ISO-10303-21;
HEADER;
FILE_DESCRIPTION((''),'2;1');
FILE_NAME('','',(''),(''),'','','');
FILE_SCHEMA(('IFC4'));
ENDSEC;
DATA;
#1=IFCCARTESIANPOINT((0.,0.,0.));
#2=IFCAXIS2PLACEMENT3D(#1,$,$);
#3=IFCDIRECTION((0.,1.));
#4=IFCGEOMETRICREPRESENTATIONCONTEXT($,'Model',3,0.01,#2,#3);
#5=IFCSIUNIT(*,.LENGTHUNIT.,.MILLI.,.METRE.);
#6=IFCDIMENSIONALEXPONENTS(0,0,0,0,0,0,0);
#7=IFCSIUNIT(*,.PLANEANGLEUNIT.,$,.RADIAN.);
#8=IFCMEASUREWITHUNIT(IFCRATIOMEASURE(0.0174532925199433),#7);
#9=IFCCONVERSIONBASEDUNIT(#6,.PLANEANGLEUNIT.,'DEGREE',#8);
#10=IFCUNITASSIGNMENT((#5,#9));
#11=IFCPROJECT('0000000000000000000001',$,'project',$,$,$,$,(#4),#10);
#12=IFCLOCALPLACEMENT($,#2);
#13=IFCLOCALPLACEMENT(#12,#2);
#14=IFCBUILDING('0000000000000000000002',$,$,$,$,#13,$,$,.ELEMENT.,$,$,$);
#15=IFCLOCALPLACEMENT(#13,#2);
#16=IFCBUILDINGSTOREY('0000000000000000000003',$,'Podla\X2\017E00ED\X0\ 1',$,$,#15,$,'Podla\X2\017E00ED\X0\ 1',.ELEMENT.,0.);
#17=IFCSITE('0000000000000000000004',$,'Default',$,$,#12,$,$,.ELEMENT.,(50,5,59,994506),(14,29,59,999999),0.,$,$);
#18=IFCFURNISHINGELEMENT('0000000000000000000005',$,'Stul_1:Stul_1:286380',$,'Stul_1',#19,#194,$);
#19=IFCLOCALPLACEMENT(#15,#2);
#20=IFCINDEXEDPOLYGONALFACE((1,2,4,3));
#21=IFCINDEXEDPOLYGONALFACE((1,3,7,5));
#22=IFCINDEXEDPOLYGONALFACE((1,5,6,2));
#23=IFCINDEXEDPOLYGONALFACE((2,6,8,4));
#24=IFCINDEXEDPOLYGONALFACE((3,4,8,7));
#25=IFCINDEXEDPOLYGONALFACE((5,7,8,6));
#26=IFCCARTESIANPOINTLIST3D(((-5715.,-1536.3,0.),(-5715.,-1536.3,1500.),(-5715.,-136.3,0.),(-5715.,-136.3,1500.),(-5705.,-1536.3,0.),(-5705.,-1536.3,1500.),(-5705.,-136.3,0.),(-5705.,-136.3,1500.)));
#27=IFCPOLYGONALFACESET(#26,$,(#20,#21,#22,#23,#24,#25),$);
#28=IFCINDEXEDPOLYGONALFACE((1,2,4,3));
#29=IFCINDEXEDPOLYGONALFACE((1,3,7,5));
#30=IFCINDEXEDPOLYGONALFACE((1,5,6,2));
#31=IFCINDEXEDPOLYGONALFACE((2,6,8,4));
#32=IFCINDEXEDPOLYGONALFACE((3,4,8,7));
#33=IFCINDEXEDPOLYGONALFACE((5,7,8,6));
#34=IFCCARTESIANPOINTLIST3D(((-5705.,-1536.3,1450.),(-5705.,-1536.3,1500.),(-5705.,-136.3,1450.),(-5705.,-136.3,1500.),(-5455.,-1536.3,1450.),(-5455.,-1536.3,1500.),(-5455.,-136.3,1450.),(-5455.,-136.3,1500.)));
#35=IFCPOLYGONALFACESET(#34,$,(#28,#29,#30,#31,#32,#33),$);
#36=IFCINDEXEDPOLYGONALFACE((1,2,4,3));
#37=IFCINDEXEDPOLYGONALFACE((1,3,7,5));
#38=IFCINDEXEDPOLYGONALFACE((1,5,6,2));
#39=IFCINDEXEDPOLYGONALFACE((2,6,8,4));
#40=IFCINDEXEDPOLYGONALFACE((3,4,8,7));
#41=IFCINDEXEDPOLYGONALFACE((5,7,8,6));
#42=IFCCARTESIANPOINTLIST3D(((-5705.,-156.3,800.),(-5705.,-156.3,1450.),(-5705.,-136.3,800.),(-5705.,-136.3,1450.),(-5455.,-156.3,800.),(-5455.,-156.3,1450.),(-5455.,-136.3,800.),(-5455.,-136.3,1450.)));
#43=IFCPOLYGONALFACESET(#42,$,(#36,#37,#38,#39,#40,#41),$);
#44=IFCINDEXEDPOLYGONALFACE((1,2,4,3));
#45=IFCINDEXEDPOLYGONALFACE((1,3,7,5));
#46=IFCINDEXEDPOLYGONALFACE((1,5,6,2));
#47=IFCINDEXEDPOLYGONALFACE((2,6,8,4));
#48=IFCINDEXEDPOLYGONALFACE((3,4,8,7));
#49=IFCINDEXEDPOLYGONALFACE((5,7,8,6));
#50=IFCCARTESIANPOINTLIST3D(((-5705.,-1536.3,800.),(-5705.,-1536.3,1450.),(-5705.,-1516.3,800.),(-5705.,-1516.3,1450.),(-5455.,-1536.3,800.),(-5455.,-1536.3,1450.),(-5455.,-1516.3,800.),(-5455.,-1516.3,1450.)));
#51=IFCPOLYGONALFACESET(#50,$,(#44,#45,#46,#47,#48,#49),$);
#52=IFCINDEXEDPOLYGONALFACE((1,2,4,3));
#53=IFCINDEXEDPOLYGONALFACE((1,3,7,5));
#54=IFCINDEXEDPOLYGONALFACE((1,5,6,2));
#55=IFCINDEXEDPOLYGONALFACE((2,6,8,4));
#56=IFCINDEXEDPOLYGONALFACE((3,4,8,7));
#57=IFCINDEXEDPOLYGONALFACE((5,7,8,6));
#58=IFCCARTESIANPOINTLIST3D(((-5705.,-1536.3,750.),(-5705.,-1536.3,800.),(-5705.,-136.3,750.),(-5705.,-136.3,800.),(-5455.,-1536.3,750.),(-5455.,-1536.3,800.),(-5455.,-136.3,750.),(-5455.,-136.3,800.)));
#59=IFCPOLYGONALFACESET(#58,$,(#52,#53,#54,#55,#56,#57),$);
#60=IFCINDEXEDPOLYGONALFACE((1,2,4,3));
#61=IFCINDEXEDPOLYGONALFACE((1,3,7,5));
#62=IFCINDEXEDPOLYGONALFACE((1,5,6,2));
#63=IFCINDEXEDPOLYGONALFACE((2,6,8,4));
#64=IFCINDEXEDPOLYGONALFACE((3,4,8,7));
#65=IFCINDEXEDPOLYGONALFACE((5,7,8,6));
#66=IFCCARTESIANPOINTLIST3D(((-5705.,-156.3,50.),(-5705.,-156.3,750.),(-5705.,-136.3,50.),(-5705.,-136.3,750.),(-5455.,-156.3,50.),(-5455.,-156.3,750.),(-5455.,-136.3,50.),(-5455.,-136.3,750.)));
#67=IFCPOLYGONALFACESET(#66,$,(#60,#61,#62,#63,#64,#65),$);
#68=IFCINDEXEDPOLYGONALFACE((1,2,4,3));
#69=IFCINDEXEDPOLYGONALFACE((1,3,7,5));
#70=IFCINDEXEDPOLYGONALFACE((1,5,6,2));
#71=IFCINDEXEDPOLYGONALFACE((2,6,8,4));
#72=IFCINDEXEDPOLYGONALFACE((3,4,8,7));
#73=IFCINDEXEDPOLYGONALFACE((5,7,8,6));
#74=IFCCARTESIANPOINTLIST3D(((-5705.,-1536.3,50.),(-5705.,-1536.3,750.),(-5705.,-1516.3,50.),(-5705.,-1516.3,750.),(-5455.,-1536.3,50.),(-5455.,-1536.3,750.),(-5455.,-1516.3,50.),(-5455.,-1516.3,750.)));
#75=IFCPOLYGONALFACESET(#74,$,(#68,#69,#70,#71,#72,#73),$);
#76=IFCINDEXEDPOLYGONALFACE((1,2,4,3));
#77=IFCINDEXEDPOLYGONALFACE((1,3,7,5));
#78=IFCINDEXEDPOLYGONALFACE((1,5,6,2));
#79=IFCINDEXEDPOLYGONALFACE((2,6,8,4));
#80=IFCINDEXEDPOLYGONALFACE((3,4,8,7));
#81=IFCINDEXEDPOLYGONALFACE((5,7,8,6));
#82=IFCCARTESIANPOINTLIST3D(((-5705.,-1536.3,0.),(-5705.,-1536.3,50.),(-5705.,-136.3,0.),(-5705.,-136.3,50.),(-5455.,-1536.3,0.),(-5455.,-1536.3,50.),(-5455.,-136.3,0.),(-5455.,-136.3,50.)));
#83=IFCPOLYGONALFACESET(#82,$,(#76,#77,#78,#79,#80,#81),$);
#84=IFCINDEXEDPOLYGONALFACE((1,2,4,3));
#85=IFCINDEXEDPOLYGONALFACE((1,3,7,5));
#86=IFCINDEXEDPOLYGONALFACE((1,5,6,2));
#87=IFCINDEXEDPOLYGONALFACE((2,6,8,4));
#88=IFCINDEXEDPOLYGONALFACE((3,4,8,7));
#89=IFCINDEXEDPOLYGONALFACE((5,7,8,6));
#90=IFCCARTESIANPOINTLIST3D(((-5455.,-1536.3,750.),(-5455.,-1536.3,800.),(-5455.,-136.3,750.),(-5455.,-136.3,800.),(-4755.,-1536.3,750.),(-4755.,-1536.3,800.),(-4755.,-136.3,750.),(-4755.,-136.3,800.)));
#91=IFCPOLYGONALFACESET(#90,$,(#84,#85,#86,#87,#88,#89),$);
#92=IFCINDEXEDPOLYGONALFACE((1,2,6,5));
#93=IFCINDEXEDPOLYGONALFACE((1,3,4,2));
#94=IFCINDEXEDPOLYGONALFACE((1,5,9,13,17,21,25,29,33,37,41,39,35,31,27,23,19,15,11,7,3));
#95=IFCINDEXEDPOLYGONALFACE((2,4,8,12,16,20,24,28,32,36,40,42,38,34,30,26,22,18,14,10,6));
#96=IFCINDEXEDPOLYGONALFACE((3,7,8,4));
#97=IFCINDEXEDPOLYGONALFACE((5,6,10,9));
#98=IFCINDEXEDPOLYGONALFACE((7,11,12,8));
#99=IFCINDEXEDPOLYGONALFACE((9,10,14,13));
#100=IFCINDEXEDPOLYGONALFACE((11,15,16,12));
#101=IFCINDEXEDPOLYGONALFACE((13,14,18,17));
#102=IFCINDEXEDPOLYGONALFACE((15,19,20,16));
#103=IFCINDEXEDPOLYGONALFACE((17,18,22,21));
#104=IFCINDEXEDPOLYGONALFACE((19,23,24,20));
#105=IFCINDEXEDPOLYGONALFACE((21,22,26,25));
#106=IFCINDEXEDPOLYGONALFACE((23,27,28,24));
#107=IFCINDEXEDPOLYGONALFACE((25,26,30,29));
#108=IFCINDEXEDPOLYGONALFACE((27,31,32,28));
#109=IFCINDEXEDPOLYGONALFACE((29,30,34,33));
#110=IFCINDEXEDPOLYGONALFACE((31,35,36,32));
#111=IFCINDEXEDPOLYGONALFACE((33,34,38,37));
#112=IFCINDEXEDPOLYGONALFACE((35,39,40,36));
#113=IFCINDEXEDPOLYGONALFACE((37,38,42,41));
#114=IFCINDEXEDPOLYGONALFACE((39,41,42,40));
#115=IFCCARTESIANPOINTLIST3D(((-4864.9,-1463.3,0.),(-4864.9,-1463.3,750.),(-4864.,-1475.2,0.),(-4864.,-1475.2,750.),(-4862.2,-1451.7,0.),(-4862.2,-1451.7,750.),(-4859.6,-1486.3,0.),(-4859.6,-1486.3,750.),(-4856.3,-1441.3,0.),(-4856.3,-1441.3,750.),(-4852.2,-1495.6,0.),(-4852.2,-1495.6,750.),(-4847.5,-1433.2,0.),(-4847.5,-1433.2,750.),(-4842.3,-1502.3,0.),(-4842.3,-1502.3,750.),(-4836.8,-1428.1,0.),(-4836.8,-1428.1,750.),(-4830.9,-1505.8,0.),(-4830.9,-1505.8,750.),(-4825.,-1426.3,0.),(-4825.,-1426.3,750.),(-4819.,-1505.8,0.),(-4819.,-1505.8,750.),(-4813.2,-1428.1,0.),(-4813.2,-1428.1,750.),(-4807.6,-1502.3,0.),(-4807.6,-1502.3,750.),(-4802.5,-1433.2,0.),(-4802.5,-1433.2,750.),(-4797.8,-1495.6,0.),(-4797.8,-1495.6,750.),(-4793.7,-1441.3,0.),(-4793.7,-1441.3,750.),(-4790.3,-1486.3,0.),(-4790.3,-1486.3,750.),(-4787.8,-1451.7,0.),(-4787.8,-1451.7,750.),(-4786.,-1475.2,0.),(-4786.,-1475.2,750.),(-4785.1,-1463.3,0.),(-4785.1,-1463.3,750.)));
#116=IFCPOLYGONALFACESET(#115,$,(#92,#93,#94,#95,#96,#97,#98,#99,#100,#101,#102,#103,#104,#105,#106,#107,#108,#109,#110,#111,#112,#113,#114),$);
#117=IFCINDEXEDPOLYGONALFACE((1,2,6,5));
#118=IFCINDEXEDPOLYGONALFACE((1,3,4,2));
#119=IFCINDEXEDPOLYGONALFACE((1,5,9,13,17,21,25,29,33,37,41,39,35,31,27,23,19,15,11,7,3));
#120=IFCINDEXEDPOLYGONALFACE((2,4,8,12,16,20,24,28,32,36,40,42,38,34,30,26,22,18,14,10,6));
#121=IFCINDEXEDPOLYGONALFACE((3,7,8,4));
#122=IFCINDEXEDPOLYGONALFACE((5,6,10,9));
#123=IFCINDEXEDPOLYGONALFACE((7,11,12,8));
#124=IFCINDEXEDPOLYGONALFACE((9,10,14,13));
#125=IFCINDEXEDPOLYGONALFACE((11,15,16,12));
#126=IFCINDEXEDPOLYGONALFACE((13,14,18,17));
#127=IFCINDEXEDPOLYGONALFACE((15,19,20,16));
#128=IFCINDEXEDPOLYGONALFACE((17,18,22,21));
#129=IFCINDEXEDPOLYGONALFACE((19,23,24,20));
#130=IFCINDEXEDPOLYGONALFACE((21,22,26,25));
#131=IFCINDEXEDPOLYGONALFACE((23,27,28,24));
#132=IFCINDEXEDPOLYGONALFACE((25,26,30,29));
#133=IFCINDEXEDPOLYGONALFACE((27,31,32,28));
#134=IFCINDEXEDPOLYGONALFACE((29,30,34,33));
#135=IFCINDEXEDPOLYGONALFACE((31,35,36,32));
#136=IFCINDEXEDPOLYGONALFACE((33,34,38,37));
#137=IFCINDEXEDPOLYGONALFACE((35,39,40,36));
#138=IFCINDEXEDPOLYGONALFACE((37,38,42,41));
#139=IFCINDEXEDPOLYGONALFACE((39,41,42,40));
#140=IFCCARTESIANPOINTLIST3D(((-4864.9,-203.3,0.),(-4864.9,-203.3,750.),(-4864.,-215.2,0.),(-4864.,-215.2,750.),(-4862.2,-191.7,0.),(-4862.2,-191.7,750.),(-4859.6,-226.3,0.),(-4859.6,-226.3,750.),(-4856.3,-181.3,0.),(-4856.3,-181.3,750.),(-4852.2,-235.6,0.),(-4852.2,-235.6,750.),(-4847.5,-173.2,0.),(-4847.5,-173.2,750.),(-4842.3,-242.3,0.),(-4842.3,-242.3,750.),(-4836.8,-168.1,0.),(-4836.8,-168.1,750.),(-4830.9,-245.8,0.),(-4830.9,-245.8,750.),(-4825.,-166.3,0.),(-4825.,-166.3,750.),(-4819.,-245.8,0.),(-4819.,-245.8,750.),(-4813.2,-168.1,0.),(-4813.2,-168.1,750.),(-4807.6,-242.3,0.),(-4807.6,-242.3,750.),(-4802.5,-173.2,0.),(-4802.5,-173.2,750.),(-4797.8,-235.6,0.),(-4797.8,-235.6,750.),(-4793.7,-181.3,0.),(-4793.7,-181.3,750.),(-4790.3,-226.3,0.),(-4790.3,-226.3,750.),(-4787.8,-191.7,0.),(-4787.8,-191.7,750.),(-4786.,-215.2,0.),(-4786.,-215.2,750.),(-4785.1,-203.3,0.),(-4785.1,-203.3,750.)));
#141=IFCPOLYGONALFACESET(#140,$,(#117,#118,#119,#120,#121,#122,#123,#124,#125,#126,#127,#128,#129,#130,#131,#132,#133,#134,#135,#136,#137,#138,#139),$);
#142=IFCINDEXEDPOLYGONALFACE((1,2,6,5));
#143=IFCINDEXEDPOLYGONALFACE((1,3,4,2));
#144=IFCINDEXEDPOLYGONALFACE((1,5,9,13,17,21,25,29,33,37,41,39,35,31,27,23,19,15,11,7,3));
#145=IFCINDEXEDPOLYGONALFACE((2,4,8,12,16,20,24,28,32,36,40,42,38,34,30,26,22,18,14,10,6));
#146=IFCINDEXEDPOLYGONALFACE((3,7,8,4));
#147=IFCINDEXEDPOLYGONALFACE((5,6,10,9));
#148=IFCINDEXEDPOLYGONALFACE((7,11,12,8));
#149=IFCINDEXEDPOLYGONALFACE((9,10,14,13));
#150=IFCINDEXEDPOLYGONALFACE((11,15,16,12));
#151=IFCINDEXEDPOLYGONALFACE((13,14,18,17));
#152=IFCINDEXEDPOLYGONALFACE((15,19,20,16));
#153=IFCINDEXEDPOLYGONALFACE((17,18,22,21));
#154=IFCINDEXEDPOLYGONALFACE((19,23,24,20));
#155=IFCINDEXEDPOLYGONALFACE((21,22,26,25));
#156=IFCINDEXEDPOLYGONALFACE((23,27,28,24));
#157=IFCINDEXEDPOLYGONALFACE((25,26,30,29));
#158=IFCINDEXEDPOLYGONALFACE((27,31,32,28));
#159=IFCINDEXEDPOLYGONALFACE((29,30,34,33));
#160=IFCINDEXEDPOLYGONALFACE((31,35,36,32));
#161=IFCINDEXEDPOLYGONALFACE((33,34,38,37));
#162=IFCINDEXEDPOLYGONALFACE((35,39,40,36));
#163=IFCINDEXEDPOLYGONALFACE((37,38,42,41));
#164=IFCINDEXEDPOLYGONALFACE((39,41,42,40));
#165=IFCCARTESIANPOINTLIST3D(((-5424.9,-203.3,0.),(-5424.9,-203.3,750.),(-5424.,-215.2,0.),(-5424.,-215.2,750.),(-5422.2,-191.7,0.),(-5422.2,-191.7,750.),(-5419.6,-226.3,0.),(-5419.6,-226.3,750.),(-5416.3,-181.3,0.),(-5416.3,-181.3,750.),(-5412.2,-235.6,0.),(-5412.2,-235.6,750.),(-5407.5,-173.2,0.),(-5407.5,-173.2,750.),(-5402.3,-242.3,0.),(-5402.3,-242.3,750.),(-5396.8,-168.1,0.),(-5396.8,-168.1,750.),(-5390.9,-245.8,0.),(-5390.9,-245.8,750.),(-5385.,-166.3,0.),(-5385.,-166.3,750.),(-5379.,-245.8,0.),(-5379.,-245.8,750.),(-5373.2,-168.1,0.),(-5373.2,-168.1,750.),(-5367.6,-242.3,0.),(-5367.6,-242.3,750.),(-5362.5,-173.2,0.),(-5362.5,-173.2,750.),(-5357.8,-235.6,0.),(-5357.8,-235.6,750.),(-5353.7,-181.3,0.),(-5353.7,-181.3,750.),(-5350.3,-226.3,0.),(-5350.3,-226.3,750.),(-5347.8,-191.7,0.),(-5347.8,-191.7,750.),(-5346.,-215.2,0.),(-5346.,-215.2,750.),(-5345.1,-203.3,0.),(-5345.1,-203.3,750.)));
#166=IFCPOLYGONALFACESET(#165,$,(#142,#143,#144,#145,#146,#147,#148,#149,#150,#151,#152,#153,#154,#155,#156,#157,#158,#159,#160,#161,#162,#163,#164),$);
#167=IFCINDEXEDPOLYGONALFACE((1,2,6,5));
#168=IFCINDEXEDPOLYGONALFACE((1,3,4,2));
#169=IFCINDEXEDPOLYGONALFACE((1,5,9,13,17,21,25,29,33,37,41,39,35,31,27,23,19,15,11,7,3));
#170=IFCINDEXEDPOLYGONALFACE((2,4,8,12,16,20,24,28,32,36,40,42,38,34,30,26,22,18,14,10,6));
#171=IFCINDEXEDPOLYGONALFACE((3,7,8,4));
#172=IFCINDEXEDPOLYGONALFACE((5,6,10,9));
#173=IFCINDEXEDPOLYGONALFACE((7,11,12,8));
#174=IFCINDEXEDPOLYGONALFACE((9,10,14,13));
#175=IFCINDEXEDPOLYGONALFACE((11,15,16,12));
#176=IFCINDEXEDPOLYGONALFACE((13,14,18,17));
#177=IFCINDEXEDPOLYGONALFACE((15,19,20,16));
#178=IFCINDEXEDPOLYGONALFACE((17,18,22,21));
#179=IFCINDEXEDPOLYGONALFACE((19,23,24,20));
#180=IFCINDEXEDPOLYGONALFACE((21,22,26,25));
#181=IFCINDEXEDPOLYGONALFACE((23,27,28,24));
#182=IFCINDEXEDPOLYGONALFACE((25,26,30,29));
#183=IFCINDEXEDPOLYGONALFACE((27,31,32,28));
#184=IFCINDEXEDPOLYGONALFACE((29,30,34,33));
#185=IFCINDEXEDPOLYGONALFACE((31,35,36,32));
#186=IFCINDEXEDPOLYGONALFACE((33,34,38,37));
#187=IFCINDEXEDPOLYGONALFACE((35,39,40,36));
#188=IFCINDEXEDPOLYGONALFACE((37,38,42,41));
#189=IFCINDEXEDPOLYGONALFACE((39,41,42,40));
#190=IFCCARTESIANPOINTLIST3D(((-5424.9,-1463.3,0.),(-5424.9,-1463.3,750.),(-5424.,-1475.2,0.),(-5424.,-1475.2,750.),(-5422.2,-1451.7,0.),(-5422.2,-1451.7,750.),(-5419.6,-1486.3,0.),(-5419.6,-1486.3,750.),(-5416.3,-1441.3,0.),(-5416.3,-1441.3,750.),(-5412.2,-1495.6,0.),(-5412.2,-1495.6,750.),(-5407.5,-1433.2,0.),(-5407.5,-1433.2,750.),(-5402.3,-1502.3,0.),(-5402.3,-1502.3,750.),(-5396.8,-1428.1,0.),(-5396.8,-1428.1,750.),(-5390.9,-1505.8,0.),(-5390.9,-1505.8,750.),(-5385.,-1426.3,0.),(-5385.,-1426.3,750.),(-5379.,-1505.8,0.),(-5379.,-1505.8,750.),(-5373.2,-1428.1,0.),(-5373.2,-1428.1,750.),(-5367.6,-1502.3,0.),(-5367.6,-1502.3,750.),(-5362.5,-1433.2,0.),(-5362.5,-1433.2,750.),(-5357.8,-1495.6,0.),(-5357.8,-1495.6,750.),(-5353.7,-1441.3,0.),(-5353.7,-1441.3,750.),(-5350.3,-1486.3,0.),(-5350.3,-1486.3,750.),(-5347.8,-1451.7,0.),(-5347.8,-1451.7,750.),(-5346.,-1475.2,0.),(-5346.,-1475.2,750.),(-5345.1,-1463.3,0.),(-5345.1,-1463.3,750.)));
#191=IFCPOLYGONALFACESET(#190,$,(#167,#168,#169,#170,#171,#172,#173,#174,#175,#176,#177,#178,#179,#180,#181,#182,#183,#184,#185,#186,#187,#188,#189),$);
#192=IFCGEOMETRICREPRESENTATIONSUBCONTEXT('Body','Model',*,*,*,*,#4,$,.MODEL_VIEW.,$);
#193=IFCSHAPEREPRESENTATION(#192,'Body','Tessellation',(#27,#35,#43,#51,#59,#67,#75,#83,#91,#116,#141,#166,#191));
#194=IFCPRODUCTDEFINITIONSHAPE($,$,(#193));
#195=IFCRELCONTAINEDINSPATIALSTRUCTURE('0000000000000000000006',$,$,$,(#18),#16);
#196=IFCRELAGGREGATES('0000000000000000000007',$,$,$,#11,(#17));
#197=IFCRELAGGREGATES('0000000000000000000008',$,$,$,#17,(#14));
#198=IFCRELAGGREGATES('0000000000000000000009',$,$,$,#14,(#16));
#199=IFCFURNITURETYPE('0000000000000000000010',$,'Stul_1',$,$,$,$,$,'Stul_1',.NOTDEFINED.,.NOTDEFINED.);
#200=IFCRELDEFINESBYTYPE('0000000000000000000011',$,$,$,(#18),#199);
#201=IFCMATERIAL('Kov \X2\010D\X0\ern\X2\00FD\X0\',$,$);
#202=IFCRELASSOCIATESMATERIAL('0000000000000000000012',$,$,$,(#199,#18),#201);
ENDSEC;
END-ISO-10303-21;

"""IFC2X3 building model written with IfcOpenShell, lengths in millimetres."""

from ifc_helpers import new_model, entity, si_unit, converted_unit, direction, frame, frame_2d, origin, origin_2d_with_axis, place, context, subcontext, project, spatial, rectangle, circle, extrude, source, transform, mapped, material, type_object, type_shapes, element, save


model = new_model("IFC2X3")

# Units and contexts
model_context = context("Model", 3, precision=0.01, world=origin(), true_north=direction((0.0, 1.0)))
body_context = subcontext(model_context, "Body", "Model", "MODEL_VIEW")
ifc_project = project(units=[si_unit("LENGTHUNIT", "METRE", prefix="MILLI"), converted_unit("PLANEANGLEUNIT", "DEGREE", entity("IfcRatioMeasure", 0.0174532925199433), si_unit("PLANEANGLEUNIT", "RADIAN"), dimensions=[0, 0, 0, 0, 0, 0, 0])], contexts=[model_context])

# Site, building, storey
site_placement = place(None, origin())
site = spatial("IfcSite", under=ifc_project, at=site_placement, Name="Default", CompositionType="ELEMENT", RefLatitude=(50, 5, 59, 994506), RefLongitude=(14, 29, 59, 999999), RefElevation=0.0)
building_placement = place(site_placement, origin())
building = spatial("IfcBuilding", under=site, at=building_placement, CompositionType="ELEMENT")
storey_placement = place(building_placement, origin())
storey = spatial("IfcBuildingStorey", under=building, at=storey_placement, Name="Podlaží 1", LongName="Podlaží 1", CompositionType="ELEMENT", Elevation=0.0)

# Furnishing element
ifc_material_1 = material(Name="Kov černý")
furniture_type = type_object("IfcFurnitureType", Name="Stul_1", ElementType="Stul_1", material=ifc_material_1)
shared_shape_1 = source(origin(), body_context, "Body", "SweptSolid", [
    extrude(rectangle(XDim=1400.0, YDim=10.0, at=origin_2d_with_axis()), frame((0.0, 605.0, 0.0), z_axis=(0.0, 0.0, 1.0), x_axis=(-1.0, 0.0, 0.0)), (0.0, 0.0, 1.0), 1500.0),
    extrude(rectangle(XDim=1400.0, YDim=250.0, at=frame_2d((0.0, 0.0), x_axis=(1.0, 0.0))), frame((0.0, 475.0, 1450.0), z_axis=(0.0, 0.0, 1.0), x_axis=(-1.0, 0.0, 0.0)), (0.0, 0.0, 1.0), 50.0),
    extrude(rectangle(XDim=20.0, YDim=250.0, at=origin_2d_with_axis()), frame((690.0, 475.0, 800.0), z_axis=(0.0, 0.0, 1.0), x_axis=(-1.0, 0.0, 0.0)), (0.0, 0.0, 1.0), 650.0),
    extrude(rectangle(XDim=20.0, YDim=250.0, at=frame_2d((0.0, 0.0), x_axis=(1.0, 0.0))), frame((-690.0, 475.0, 800.0), z_axis=(0.0, 0.0, 1.0), x_axis=(-1.0, 0.0, 0.0)), (0.0, 0.0, 1.0), 650.0),
    extrude(rectangle(XDim=1400.0, YDim=250.0, at=origin_2d_with_axis()), frame((0.0, 475.0, 750.0), z_axis=(0.0, 0.0, 1.0), x_axis=(-1.0, 0.0, 0.0)), (0.0, 0.0, 1.0), 50.0),
    extrude(rectangle(XDim=20.0, YDim=250.0, at=origin_2d_with_axis()), frame((690.0, 475.0, 50.0), z_axis=(0.0, 0.0, 1.0), x_axis=(-1.0, 0.0, 0.0)), (0.0, 0.0, 1.0), 700.0),
    extrude(rectangle(XDim=20.0, YDim=250.0, at=frame_2d((0.0, 0.0), x_axis=(1.0, 0.0))), frame((-690.0, 475.0, 50.0), z_axis=(0.0, 0.0, 1.0), x_axis=(-1.0, 0.0, 0.0)), (0.0, 0.0, 1.0), 700.0),
    extrude(rectangle(XDim=1400.0, YDim=250.0, at=origin_2d_with_axis()), frame((0.0, 475.0, 0.0), z_axis=(0.0, 0.0, 1.0), x_axis=(-1.0, 0.0, 0.0)), (0.0, 0.0, 1.0), 50.0),
    extrude(rectangle(XDim=1400.0, YDim=700.0, at=origin_2d_with_axis()), frame((0.0, 0.0, 750.0), z_axis=(0.0, 0.0, 1.0), x_axis=(-1.0, 0.0, 0.0)), (0.0, 0.0, 1.0), 50.0),
    extrude(circle(Radius=40.0, at=frame_2d((0.0, 0.0), x_axis=(1.0, 0.0))), frame((-630.0, -280.0, 0.0)), (0.0, 0.0, 1.0), 750.0),
    extrude(circle(Radius=40.0, at=frame_2d((0.0, 0.0), x_axis=(1.0, 0.0))), frame((630.0, -280.0, 0.0)), (0.0, 0.0, 1.0), 750.0),
    extrude(circle(Radius=40.0, at=frame_2d((0.0, 0.0), x_axis=(1.0, 0.0))), frame((630.0, 280.0, 0.0)), (0.0, 0.0, 1.0), 750.0),
    extrude(circle(Radius=40.0, at=frame_2d((0.0, 0.0), x_axis=(1.0, 0.0))), frame((-630.0, 280.0, 0.0)), (0.0, 0.0, 1.0), 750.0),
])
type_shapes(furniture_type, [shared_shape_1])
for number, where, z_axis, x_axis, name in (
    (1, (-5105.0, -836.3, 0.0), (0.0, 0.0, 1.0), (0.0, 1.0, 0.0), "Stul_1:Stul_1:286380"),
):
    element("IfcFurnishingElement", number, at=place(storey_placement, frame(where, z_axis=z_axis, x_axis=x_axis)), inside=storey, type_object=furniture_type, material=ifc_material_1, Name=name, ObjectType="Stul_1", context=body_context, shape_type="MappedRepresentation", body=[
        mapped(shared_shape_1, transform((0.0, 0.0, 0.0), scale=1.0)),
    ])

save(model, "model.ifc")
